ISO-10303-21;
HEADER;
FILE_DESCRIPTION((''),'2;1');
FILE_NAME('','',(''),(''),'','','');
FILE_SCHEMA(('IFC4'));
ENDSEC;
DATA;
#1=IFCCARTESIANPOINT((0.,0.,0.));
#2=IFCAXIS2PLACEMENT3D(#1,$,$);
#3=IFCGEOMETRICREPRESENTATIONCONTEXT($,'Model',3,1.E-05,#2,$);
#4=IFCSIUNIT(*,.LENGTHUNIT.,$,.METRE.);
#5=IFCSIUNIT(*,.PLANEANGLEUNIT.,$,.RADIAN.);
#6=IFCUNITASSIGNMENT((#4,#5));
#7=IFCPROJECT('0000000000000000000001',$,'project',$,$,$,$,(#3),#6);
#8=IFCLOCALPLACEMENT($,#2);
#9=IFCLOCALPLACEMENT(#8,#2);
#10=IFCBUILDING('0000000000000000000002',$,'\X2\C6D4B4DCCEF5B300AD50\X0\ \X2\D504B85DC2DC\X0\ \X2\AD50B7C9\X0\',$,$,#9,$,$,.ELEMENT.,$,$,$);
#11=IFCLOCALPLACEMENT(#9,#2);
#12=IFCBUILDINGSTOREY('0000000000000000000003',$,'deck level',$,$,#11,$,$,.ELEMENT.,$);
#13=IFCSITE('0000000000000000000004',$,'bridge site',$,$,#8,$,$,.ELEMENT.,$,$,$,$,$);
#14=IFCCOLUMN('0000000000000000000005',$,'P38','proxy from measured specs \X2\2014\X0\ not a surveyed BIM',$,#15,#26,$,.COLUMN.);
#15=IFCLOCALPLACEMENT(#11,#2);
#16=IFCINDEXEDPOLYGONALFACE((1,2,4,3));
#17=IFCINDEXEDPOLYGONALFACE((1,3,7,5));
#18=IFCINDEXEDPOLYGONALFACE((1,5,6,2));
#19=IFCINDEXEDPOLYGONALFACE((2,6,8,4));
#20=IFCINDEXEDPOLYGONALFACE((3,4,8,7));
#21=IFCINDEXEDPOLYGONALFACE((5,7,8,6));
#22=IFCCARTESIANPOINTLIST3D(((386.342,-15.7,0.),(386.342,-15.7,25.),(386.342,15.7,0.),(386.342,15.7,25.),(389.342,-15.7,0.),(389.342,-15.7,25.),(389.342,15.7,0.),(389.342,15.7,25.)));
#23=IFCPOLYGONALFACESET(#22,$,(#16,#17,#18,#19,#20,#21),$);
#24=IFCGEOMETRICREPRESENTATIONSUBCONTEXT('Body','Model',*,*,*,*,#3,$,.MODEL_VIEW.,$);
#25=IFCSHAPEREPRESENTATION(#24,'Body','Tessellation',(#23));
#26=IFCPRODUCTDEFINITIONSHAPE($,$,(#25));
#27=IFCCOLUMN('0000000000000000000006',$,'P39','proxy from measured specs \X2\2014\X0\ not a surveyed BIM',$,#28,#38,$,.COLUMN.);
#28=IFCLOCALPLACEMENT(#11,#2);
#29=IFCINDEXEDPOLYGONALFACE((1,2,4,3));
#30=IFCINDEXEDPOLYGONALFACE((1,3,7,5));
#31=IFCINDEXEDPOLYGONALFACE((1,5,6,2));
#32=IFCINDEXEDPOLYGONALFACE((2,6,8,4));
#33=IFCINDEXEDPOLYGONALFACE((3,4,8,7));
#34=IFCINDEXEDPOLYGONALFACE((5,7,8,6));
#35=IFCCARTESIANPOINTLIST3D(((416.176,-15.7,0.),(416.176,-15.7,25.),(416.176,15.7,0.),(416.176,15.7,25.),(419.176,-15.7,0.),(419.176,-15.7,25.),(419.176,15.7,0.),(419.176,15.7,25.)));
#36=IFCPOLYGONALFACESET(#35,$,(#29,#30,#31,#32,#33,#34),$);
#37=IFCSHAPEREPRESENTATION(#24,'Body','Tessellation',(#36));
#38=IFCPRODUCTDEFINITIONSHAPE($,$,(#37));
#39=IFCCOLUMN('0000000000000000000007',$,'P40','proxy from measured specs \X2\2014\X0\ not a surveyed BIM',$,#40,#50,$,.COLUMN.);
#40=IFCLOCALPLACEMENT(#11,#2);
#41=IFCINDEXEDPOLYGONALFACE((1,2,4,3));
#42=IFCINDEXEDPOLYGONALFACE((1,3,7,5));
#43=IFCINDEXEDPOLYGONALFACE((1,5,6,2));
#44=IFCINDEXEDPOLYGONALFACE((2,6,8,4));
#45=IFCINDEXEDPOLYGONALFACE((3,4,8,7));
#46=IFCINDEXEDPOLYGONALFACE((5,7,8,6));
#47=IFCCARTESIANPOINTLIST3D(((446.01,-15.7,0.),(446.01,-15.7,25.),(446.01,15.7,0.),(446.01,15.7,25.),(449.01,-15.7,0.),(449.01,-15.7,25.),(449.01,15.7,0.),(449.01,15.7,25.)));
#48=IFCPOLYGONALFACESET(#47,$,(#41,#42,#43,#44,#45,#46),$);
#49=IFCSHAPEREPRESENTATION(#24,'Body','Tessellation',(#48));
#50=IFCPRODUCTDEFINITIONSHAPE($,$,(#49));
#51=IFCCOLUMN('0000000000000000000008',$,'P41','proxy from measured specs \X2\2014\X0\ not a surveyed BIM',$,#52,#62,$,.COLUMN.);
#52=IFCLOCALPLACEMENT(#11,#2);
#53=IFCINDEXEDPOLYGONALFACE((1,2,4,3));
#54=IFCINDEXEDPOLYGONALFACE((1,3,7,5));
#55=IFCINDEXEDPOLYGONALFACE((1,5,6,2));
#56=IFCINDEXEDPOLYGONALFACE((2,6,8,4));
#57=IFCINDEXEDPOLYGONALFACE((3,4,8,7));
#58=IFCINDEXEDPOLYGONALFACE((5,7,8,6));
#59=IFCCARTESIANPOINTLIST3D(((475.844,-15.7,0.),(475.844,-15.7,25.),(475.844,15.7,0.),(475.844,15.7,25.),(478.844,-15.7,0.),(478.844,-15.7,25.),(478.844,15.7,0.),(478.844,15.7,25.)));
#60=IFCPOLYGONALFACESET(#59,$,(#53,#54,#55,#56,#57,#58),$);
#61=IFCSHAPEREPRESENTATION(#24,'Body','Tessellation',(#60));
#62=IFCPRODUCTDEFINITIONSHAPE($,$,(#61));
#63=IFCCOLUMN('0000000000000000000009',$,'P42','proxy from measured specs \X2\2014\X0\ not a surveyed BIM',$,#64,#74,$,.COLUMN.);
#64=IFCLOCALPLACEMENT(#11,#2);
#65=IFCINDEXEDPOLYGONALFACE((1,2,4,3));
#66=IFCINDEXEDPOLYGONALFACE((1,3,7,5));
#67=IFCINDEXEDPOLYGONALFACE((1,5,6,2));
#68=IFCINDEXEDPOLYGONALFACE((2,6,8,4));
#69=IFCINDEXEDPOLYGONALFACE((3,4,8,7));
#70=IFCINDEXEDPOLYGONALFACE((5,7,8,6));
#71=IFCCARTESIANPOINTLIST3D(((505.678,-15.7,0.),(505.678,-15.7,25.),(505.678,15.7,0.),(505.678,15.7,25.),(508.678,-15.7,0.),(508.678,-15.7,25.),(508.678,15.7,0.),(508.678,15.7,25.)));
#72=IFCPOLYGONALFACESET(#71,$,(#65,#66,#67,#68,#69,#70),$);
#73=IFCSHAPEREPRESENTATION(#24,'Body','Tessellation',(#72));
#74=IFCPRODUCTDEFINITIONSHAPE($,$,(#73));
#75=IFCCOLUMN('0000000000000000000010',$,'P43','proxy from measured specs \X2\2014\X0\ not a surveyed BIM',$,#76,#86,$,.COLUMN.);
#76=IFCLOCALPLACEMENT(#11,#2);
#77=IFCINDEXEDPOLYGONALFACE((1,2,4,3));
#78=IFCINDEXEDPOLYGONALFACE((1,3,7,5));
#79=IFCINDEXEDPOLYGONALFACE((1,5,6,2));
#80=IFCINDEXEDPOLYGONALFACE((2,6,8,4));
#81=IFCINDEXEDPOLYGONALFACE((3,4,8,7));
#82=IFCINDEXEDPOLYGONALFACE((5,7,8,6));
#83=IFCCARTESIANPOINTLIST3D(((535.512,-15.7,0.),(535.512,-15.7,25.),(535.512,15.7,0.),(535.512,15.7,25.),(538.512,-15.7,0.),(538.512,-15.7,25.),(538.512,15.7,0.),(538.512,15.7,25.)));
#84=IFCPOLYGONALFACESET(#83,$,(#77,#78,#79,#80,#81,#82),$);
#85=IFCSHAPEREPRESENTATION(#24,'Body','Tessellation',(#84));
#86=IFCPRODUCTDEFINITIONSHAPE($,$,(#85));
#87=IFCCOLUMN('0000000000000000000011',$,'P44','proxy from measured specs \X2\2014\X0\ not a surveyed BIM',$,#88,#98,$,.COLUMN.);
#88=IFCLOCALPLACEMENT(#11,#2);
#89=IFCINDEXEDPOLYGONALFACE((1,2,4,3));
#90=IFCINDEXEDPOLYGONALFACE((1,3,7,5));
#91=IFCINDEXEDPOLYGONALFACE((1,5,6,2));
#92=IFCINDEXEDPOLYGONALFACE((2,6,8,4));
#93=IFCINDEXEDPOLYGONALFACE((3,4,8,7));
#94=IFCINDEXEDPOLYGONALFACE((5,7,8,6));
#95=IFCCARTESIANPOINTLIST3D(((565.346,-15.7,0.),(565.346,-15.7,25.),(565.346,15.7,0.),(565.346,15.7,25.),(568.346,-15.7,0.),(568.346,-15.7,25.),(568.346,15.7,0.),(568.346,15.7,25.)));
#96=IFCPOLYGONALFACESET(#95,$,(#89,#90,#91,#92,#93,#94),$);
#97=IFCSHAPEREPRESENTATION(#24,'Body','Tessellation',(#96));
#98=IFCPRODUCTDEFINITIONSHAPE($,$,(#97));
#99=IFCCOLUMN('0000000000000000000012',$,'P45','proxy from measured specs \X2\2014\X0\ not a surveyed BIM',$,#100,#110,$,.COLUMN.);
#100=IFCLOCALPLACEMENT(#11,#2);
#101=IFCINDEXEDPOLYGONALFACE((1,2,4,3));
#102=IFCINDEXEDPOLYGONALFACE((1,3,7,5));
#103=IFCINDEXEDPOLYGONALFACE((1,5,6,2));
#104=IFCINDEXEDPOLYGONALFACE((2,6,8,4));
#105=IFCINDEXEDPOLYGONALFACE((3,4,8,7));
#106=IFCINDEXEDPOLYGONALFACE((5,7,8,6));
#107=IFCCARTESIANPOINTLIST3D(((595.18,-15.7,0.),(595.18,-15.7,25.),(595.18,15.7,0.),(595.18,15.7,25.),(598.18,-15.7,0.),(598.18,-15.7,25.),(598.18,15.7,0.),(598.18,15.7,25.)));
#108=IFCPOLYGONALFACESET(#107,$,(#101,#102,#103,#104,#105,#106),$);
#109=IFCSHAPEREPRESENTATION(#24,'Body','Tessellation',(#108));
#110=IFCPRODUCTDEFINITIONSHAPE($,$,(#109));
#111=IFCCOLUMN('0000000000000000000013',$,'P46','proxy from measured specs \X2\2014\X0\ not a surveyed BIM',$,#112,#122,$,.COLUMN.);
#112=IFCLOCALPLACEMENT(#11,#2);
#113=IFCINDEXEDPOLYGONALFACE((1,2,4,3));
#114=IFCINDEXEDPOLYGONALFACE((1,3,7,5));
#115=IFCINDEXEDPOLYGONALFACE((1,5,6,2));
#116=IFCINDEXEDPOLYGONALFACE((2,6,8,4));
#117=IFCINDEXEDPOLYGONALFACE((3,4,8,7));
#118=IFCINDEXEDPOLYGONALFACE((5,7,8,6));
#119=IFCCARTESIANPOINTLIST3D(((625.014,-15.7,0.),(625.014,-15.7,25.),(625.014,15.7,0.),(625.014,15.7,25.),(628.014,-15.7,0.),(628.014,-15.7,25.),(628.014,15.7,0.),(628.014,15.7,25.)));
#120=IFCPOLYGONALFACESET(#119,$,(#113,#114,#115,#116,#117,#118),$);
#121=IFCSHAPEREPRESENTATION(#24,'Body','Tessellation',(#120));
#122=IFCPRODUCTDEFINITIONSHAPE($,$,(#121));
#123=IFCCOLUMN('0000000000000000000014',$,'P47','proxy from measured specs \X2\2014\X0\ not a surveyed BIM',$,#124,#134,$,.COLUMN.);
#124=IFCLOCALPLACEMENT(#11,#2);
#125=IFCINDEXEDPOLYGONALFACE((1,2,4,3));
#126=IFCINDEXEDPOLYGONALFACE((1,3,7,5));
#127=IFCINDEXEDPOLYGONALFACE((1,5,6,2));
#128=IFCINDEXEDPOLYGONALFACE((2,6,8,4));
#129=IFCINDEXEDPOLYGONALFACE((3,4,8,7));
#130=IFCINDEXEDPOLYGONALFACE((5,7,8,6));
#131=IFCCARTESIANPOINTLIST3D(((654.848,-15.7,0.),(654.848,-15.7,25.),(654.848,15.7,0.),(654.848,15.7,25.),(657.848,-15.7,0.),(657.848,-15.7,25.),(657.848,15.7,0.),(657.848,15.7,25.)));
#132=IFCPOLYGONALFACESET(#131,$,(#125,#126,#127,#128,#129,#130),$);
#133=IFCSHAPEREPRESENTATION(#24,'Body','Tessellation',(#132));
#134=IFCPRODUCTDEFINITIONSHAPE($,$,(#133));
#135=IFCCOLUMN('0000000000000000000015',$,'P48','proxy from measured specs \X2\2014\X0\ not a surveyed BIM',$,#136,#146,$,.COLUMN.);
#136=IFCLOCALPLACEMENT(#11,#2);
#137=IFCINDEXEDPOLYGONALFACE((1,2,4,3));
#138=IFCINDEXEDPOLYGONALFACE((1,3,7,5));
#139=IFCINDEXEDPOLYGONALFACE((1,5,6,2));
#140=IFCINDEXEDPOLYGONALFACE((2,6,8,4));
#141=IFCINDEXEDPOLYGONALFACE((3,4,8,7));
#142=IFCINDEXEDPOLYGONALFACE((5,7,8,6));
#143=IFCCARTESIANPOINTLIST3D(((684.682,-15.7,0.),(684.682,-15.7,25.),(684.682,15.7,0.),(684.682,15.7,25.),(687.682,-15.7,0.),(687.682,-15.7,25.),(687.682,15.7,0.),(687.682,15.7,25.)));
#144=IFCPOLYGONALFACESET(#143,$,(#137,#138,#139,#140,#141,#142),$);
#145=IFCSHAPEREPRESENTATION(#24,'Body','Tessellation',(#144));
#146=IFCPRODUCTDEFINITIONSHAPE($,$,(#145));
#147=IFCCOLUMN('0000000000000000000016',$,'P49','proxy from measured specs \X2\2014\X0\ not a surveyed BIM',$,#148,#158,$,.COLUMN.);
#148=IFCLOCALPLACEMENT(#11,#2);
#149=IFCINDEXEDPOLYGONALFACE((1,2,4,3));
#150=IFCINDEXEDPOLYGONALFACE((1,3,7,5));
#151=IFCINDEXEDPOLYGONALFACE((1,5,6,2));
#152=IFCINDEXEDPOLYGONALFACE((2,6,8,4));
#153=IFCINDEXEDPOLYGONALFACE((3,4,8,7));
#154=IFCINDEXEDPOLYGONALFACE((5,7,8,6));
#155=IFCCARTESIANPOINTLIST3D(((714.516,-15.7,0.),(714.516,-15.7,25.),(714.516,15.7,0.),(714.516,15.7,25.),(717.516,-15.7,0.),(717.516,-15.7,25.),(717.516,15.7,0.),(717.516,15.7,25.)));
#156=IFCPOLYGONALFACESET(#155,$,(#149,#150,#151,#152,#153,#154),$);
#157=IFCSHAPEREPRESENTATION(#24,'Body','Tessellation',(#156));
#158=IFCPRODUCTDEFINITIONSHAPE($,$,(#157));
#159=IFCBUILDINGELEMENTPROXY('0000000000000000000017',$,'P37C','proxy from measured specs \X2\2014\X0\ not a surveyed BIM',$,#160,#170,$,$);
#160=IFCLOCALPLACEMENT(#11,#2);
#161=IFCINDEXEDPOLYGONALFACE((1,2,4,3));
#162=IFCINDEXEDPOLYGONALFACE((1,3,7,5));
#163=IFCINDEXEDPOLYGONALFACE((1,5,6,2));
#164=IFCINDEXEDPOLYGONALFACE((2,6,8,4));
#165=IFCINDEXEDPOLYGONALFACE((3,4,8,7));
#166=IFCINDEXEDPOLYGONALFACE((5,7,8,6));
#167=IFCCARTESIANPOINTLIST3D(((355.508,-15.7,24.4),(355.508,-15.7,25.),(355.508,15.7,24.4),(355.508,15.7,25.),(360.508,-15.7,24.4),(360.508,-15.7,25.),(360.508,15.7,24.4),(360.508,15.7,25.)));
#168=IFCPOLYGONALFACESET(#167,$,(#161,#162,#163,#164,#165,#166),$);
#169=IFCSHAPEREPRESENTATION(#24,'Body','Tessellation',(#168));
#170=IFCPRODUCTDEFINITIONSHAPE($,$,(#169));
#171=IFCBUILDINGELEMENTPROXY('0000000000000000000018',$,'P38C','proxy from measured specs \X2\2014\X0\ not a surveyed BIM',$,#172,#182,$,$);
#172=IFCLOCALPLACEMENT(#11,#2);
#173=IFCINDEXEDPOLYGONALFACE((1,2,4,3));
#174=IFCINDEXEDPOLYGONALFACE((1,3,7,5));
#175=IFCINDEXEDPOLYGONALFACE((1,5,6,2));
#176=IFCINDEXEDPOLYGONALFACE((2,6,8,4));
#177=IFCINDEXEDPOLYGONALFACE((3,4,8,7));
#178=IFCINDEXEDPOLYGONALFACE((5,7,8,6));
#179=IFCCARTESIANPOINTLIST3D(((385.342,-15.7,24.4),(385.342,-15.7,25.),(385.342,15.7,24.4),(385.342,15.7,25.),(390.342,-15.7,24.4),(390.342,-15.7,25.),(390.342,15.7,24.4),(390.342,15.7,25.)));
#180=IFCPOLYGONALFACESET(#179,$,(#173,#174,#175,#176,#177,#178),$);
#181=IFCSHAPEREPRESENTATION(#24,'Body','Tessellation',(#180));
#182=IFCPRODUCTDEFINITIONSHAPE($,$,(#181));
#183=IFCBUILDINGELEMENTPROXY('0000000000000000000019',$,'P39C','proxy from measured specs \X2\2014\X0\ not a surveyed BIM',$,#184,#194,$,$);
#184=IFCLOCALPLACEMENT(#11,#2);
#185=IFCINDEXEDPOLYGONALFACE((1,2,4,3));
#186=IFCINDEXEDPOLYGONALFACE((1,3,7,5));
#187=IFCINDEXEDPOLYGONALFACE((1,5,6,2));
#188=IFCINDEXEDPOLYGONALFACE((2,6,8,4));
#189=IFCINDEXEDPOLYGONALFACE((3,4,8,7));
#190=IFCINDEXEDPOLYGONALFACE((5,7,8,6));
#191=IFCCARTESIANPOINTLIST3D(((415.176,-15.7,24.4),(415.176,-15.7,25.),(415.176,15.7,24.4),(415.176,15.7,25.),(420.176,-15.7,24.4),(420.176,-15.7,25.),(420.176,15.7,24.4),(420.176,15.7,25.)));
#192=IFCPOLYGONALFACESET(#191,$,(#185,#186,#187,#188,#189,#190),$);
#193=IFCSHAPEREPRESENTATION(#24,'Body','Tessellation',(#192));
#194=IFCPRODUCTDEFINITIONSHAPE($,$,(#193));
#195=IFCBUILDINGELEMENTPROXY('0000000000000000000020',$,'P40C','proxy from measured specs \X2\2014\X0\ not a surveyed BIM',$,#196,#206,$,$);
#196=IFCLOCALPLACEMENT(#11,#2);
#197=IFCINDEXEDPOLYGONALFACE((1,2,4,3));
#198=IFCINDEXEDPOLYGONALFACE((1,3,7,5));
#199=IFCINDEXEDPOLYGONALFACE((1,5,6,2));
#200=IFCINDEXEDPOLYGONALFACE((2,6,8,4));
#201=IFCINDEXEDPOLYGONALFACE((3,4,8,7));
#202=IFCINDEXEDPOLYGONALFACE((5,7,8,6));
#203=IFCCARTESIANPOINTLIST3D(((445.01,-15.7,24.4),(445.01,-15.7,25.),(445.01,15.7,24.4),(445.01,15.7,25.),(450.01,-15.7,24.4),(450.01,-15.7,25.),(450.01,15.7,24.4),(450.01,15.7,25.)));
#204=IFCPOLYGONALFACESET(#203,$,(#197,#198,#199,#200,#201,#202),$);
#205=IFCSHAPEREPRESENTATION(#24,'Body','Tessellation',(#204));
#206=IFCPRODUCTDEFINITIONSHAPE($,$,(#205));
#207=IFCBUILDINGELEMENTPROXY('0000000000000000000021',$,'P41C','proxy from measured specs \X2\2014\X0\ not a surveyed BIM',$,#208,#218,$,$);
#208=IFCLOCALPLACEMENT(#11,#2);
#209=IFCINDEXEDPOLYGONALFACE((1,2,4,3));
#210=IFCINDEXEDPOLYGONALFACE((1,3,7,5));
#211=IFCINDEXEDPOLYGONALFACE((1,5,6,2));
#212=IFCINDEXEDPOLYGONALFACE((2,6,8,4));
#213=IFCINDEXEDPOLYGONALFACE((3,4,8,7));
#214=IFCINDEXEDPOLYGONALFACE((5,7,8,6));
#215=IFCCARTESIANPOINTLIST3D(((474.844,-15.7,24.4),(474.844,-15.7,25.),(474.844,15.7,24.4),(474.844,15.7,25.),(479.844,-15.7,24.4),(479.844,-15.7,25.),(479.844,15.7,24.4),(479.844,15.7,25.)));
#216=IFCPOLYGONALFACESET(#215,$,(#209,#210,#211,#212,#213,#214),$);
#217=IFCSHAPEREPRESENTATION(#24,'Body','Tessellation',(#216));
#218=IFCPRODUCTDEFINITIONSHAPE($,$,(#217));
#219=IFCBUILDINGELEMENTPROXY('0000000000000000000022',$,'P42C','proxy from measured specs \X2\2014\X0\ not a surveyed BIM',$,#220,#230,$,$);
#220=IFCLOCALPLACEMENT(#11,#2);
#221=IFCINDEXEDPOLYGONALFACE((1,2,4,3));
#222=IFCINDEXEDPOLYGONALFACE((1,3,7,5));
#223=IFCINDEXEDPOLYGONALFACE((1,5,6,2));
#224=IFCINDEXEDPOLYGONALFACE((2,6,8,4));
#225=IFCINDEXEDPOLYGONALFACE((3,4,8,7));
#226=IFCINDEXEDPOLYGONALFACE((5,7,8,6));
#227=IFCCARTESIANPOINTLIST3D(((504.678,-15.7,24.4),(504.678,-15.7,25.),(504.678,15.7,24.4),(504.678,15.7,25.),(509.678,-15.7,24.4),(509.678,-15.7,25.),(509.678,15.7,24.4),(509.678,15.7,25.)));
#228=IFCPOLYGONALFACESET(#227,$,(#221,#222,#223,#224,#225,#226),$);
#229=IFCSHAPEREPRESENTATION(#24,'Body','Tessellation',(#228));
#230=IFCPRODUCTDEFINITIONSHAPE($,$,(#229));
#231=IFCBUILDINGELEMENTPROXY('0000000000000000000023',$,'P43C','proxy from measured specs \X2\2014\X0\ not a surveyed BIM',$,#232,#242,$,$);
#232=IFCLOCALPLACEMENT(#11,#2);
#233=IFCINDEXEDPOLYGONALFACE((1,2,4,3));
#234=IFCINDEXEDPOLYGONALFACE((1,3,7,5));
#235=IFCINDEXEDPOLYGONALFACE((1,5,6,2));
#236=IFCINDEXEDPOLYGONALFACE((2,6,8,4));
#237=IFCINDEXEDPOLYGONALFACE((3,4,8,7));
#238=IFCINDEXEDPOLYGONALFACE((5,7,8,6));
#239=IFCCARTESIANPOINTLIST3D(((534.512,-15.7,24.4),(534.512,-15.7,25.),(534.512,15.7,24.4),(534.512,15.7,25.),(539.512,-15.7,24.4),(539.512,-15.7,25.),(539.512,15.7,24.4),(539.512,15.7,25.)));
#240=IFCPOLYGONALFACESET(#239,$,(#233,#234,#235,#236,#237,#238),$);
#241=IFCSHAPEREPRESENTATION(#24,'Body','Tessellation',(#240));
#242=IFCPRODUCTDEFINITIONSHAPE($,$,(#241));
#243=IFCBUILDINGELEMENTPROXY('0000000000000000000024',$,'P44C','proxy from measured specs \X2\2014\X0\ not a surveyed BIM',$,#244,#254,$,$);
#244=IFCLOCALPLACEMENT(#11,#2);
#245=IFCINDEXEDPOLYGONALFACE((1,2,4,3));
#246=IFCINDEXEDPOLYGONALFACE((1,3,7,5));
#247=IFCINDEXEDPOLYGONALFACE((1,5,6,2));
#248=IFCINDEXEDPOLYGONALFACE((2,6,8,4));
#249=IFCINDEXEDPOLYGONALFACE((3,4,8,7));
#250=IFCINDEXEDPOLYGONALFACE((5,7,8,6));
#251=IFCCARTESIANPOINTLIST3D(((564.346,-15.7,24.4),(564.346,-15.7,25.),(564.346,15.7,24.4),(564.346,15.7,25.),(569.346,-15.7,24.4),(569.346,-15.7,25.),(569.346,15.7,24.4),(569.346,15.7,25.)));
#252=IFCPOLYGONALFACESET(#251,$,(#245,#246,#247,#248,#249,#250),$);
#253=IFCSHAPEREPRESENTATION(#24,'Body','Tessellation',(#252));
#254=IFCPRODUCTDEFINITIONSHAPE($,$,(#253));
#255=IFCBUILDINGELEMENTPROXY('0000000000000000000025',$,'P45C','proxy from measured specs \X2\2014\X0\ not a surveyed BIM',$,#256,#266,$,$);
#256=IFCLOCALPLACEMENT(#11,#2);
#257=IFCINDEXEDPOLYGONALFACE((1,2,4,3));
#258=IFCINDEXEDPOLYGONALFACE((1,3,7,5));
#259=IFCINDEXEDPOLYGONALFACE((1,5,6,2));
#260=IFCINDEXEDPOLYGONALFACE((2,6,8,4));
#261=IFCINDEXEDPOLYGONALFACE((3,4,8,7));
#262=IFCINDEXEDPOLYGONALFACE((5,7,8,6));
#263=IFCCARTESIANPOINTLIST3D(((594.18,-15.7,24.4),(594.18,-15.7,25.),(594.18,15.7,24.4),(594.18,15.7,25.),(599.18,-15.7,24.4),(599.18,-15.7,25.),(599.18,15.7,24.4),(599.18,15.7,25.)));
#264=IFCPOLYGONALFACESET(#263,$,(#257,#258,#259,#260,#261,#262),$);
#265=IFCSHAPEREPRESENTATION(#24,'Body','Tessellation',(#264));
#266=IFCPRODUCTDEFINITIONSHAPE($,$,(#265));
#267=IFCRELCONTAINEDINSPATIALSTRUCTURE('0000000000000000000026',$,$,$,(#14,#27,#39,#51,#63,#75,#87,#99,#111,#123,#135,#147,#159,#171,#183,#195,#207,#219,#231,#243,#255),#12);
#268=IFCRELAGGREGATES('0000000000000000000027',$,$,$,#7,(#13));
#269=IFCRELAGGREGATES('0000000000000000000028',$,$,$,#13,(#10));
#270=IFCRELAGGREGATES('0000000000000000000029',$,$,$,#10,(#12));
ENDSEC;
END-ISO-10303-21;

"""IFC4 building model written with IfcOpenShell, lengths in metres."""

from ifc_helpers import new_model, si_unit, frame, origin, origin_2d, place, context, subcontext, project, spatial, rectangle, extrude, element, save


model = new_model("IFC4")

# Units and contexts
model_context = context("Model", 3, precision=1e-05, world=origin())
body_context = subcontext(model_context, "Body", "Model", "MODEL_VIEW")
ifc_project = project(units=[si_unit("LENGTHUNIT", "METRE"), si_unit("PLANEANGLEUNIT", "RADIAN")], contexts=[model_context])

# Site, building, storey
site_placement = place(None, origin())
site = spatial("IfcSite", under=ifc_project, at=site_placement, Name="bridge site", CompositionType="ELEMENT")
building_placement = place(site_placement, origin())
building = spatial("IfcBuilding", under=site, at=building_placement, Name="월드컵대교 프록시 교량", CompositionType="ELEMENT")
storey_placement = place(building_placement, origin())
storey = spatial("IfcBuildingStorey", under=building, at=storey_placement, Name="deck level", CompositionType="ELEMENT")

# Columns
for number, where, name in (
    (1, (387.842, 0.0, 0.0), "P38"),
    (2, (417.676, 0.0, 0.0), "P39"),
    (3, (447.51, 0.0, 0.0), "P40"),
    (4, (477.344, 0.0, 0.0), "P41"),
    (5, (507.178, 0.0, 0.0), "P42"),
    (6, (537.012, 0.0, 0.0), "P43"),
    (7, (566.846, 0.0, 0.0), "P44"),
    (8, (596.68, 0.0, 0.0), "P45"),
    (9, (626.514, 0.0, 0.0), "P46"),
    (10, (656.348, 0.0, 0.0), "P47"),
    (11, (686.182, 0.0, 0.0), "P48"),
    (12, (716.016, 0.0, 0.0), "P49"),
):
    element("IfcColumn", number, at=place(storey_placement, frame(where)), inside=storey, Name=name, Description="proxy from measured specs — not a surveyed BIM", PredefinedType="COLUMN", context=body_context, shape_type="SweptSolid", body=[
        extrude(rectangle(XDim=3.0, YDim=31.4, at=origin_2d()), origin(), (0.0, 0.0, 1.0), 25.0),
    ])

# Building element proxies
for number, where, name in (
    (13, (358.008, 0.0, 24.4), "P37C"),
    (14, (387.842, 0.0, 24.4), "P38C"),
    (15, (417.676, 0.0, 24.4), "P39C"),
    (16, (447.51, 0.0, 24.4), "P40C"),
    (17, (477.344, 0.0, 24.4), "P41C"),
    (18, (507.178, 0.0, 24.4), "P42C"),
    (19, (537.012, 0.0, 24.4), "P43C"),
    (20, (566.846, 0.0, 24.4), "P44C"),
    (21, (596.68, 0.0, 24.4), "P45C"),
):
    element("IfcBuildingElementProxy", number, at=place(storey_placement, frame(where)), inside=storey, Name=name, Description="proxy from measured specs — not a surveyed BIM", context=body_context, shape_type="SweptSolid", body=[
        extrude(rectangle(XDim=5.0, YDim=31.4, at=origin_2d()), origin(), (0.0, 0.0, 1.0), 0.6),
    ])

save(model, "model.ifc")
